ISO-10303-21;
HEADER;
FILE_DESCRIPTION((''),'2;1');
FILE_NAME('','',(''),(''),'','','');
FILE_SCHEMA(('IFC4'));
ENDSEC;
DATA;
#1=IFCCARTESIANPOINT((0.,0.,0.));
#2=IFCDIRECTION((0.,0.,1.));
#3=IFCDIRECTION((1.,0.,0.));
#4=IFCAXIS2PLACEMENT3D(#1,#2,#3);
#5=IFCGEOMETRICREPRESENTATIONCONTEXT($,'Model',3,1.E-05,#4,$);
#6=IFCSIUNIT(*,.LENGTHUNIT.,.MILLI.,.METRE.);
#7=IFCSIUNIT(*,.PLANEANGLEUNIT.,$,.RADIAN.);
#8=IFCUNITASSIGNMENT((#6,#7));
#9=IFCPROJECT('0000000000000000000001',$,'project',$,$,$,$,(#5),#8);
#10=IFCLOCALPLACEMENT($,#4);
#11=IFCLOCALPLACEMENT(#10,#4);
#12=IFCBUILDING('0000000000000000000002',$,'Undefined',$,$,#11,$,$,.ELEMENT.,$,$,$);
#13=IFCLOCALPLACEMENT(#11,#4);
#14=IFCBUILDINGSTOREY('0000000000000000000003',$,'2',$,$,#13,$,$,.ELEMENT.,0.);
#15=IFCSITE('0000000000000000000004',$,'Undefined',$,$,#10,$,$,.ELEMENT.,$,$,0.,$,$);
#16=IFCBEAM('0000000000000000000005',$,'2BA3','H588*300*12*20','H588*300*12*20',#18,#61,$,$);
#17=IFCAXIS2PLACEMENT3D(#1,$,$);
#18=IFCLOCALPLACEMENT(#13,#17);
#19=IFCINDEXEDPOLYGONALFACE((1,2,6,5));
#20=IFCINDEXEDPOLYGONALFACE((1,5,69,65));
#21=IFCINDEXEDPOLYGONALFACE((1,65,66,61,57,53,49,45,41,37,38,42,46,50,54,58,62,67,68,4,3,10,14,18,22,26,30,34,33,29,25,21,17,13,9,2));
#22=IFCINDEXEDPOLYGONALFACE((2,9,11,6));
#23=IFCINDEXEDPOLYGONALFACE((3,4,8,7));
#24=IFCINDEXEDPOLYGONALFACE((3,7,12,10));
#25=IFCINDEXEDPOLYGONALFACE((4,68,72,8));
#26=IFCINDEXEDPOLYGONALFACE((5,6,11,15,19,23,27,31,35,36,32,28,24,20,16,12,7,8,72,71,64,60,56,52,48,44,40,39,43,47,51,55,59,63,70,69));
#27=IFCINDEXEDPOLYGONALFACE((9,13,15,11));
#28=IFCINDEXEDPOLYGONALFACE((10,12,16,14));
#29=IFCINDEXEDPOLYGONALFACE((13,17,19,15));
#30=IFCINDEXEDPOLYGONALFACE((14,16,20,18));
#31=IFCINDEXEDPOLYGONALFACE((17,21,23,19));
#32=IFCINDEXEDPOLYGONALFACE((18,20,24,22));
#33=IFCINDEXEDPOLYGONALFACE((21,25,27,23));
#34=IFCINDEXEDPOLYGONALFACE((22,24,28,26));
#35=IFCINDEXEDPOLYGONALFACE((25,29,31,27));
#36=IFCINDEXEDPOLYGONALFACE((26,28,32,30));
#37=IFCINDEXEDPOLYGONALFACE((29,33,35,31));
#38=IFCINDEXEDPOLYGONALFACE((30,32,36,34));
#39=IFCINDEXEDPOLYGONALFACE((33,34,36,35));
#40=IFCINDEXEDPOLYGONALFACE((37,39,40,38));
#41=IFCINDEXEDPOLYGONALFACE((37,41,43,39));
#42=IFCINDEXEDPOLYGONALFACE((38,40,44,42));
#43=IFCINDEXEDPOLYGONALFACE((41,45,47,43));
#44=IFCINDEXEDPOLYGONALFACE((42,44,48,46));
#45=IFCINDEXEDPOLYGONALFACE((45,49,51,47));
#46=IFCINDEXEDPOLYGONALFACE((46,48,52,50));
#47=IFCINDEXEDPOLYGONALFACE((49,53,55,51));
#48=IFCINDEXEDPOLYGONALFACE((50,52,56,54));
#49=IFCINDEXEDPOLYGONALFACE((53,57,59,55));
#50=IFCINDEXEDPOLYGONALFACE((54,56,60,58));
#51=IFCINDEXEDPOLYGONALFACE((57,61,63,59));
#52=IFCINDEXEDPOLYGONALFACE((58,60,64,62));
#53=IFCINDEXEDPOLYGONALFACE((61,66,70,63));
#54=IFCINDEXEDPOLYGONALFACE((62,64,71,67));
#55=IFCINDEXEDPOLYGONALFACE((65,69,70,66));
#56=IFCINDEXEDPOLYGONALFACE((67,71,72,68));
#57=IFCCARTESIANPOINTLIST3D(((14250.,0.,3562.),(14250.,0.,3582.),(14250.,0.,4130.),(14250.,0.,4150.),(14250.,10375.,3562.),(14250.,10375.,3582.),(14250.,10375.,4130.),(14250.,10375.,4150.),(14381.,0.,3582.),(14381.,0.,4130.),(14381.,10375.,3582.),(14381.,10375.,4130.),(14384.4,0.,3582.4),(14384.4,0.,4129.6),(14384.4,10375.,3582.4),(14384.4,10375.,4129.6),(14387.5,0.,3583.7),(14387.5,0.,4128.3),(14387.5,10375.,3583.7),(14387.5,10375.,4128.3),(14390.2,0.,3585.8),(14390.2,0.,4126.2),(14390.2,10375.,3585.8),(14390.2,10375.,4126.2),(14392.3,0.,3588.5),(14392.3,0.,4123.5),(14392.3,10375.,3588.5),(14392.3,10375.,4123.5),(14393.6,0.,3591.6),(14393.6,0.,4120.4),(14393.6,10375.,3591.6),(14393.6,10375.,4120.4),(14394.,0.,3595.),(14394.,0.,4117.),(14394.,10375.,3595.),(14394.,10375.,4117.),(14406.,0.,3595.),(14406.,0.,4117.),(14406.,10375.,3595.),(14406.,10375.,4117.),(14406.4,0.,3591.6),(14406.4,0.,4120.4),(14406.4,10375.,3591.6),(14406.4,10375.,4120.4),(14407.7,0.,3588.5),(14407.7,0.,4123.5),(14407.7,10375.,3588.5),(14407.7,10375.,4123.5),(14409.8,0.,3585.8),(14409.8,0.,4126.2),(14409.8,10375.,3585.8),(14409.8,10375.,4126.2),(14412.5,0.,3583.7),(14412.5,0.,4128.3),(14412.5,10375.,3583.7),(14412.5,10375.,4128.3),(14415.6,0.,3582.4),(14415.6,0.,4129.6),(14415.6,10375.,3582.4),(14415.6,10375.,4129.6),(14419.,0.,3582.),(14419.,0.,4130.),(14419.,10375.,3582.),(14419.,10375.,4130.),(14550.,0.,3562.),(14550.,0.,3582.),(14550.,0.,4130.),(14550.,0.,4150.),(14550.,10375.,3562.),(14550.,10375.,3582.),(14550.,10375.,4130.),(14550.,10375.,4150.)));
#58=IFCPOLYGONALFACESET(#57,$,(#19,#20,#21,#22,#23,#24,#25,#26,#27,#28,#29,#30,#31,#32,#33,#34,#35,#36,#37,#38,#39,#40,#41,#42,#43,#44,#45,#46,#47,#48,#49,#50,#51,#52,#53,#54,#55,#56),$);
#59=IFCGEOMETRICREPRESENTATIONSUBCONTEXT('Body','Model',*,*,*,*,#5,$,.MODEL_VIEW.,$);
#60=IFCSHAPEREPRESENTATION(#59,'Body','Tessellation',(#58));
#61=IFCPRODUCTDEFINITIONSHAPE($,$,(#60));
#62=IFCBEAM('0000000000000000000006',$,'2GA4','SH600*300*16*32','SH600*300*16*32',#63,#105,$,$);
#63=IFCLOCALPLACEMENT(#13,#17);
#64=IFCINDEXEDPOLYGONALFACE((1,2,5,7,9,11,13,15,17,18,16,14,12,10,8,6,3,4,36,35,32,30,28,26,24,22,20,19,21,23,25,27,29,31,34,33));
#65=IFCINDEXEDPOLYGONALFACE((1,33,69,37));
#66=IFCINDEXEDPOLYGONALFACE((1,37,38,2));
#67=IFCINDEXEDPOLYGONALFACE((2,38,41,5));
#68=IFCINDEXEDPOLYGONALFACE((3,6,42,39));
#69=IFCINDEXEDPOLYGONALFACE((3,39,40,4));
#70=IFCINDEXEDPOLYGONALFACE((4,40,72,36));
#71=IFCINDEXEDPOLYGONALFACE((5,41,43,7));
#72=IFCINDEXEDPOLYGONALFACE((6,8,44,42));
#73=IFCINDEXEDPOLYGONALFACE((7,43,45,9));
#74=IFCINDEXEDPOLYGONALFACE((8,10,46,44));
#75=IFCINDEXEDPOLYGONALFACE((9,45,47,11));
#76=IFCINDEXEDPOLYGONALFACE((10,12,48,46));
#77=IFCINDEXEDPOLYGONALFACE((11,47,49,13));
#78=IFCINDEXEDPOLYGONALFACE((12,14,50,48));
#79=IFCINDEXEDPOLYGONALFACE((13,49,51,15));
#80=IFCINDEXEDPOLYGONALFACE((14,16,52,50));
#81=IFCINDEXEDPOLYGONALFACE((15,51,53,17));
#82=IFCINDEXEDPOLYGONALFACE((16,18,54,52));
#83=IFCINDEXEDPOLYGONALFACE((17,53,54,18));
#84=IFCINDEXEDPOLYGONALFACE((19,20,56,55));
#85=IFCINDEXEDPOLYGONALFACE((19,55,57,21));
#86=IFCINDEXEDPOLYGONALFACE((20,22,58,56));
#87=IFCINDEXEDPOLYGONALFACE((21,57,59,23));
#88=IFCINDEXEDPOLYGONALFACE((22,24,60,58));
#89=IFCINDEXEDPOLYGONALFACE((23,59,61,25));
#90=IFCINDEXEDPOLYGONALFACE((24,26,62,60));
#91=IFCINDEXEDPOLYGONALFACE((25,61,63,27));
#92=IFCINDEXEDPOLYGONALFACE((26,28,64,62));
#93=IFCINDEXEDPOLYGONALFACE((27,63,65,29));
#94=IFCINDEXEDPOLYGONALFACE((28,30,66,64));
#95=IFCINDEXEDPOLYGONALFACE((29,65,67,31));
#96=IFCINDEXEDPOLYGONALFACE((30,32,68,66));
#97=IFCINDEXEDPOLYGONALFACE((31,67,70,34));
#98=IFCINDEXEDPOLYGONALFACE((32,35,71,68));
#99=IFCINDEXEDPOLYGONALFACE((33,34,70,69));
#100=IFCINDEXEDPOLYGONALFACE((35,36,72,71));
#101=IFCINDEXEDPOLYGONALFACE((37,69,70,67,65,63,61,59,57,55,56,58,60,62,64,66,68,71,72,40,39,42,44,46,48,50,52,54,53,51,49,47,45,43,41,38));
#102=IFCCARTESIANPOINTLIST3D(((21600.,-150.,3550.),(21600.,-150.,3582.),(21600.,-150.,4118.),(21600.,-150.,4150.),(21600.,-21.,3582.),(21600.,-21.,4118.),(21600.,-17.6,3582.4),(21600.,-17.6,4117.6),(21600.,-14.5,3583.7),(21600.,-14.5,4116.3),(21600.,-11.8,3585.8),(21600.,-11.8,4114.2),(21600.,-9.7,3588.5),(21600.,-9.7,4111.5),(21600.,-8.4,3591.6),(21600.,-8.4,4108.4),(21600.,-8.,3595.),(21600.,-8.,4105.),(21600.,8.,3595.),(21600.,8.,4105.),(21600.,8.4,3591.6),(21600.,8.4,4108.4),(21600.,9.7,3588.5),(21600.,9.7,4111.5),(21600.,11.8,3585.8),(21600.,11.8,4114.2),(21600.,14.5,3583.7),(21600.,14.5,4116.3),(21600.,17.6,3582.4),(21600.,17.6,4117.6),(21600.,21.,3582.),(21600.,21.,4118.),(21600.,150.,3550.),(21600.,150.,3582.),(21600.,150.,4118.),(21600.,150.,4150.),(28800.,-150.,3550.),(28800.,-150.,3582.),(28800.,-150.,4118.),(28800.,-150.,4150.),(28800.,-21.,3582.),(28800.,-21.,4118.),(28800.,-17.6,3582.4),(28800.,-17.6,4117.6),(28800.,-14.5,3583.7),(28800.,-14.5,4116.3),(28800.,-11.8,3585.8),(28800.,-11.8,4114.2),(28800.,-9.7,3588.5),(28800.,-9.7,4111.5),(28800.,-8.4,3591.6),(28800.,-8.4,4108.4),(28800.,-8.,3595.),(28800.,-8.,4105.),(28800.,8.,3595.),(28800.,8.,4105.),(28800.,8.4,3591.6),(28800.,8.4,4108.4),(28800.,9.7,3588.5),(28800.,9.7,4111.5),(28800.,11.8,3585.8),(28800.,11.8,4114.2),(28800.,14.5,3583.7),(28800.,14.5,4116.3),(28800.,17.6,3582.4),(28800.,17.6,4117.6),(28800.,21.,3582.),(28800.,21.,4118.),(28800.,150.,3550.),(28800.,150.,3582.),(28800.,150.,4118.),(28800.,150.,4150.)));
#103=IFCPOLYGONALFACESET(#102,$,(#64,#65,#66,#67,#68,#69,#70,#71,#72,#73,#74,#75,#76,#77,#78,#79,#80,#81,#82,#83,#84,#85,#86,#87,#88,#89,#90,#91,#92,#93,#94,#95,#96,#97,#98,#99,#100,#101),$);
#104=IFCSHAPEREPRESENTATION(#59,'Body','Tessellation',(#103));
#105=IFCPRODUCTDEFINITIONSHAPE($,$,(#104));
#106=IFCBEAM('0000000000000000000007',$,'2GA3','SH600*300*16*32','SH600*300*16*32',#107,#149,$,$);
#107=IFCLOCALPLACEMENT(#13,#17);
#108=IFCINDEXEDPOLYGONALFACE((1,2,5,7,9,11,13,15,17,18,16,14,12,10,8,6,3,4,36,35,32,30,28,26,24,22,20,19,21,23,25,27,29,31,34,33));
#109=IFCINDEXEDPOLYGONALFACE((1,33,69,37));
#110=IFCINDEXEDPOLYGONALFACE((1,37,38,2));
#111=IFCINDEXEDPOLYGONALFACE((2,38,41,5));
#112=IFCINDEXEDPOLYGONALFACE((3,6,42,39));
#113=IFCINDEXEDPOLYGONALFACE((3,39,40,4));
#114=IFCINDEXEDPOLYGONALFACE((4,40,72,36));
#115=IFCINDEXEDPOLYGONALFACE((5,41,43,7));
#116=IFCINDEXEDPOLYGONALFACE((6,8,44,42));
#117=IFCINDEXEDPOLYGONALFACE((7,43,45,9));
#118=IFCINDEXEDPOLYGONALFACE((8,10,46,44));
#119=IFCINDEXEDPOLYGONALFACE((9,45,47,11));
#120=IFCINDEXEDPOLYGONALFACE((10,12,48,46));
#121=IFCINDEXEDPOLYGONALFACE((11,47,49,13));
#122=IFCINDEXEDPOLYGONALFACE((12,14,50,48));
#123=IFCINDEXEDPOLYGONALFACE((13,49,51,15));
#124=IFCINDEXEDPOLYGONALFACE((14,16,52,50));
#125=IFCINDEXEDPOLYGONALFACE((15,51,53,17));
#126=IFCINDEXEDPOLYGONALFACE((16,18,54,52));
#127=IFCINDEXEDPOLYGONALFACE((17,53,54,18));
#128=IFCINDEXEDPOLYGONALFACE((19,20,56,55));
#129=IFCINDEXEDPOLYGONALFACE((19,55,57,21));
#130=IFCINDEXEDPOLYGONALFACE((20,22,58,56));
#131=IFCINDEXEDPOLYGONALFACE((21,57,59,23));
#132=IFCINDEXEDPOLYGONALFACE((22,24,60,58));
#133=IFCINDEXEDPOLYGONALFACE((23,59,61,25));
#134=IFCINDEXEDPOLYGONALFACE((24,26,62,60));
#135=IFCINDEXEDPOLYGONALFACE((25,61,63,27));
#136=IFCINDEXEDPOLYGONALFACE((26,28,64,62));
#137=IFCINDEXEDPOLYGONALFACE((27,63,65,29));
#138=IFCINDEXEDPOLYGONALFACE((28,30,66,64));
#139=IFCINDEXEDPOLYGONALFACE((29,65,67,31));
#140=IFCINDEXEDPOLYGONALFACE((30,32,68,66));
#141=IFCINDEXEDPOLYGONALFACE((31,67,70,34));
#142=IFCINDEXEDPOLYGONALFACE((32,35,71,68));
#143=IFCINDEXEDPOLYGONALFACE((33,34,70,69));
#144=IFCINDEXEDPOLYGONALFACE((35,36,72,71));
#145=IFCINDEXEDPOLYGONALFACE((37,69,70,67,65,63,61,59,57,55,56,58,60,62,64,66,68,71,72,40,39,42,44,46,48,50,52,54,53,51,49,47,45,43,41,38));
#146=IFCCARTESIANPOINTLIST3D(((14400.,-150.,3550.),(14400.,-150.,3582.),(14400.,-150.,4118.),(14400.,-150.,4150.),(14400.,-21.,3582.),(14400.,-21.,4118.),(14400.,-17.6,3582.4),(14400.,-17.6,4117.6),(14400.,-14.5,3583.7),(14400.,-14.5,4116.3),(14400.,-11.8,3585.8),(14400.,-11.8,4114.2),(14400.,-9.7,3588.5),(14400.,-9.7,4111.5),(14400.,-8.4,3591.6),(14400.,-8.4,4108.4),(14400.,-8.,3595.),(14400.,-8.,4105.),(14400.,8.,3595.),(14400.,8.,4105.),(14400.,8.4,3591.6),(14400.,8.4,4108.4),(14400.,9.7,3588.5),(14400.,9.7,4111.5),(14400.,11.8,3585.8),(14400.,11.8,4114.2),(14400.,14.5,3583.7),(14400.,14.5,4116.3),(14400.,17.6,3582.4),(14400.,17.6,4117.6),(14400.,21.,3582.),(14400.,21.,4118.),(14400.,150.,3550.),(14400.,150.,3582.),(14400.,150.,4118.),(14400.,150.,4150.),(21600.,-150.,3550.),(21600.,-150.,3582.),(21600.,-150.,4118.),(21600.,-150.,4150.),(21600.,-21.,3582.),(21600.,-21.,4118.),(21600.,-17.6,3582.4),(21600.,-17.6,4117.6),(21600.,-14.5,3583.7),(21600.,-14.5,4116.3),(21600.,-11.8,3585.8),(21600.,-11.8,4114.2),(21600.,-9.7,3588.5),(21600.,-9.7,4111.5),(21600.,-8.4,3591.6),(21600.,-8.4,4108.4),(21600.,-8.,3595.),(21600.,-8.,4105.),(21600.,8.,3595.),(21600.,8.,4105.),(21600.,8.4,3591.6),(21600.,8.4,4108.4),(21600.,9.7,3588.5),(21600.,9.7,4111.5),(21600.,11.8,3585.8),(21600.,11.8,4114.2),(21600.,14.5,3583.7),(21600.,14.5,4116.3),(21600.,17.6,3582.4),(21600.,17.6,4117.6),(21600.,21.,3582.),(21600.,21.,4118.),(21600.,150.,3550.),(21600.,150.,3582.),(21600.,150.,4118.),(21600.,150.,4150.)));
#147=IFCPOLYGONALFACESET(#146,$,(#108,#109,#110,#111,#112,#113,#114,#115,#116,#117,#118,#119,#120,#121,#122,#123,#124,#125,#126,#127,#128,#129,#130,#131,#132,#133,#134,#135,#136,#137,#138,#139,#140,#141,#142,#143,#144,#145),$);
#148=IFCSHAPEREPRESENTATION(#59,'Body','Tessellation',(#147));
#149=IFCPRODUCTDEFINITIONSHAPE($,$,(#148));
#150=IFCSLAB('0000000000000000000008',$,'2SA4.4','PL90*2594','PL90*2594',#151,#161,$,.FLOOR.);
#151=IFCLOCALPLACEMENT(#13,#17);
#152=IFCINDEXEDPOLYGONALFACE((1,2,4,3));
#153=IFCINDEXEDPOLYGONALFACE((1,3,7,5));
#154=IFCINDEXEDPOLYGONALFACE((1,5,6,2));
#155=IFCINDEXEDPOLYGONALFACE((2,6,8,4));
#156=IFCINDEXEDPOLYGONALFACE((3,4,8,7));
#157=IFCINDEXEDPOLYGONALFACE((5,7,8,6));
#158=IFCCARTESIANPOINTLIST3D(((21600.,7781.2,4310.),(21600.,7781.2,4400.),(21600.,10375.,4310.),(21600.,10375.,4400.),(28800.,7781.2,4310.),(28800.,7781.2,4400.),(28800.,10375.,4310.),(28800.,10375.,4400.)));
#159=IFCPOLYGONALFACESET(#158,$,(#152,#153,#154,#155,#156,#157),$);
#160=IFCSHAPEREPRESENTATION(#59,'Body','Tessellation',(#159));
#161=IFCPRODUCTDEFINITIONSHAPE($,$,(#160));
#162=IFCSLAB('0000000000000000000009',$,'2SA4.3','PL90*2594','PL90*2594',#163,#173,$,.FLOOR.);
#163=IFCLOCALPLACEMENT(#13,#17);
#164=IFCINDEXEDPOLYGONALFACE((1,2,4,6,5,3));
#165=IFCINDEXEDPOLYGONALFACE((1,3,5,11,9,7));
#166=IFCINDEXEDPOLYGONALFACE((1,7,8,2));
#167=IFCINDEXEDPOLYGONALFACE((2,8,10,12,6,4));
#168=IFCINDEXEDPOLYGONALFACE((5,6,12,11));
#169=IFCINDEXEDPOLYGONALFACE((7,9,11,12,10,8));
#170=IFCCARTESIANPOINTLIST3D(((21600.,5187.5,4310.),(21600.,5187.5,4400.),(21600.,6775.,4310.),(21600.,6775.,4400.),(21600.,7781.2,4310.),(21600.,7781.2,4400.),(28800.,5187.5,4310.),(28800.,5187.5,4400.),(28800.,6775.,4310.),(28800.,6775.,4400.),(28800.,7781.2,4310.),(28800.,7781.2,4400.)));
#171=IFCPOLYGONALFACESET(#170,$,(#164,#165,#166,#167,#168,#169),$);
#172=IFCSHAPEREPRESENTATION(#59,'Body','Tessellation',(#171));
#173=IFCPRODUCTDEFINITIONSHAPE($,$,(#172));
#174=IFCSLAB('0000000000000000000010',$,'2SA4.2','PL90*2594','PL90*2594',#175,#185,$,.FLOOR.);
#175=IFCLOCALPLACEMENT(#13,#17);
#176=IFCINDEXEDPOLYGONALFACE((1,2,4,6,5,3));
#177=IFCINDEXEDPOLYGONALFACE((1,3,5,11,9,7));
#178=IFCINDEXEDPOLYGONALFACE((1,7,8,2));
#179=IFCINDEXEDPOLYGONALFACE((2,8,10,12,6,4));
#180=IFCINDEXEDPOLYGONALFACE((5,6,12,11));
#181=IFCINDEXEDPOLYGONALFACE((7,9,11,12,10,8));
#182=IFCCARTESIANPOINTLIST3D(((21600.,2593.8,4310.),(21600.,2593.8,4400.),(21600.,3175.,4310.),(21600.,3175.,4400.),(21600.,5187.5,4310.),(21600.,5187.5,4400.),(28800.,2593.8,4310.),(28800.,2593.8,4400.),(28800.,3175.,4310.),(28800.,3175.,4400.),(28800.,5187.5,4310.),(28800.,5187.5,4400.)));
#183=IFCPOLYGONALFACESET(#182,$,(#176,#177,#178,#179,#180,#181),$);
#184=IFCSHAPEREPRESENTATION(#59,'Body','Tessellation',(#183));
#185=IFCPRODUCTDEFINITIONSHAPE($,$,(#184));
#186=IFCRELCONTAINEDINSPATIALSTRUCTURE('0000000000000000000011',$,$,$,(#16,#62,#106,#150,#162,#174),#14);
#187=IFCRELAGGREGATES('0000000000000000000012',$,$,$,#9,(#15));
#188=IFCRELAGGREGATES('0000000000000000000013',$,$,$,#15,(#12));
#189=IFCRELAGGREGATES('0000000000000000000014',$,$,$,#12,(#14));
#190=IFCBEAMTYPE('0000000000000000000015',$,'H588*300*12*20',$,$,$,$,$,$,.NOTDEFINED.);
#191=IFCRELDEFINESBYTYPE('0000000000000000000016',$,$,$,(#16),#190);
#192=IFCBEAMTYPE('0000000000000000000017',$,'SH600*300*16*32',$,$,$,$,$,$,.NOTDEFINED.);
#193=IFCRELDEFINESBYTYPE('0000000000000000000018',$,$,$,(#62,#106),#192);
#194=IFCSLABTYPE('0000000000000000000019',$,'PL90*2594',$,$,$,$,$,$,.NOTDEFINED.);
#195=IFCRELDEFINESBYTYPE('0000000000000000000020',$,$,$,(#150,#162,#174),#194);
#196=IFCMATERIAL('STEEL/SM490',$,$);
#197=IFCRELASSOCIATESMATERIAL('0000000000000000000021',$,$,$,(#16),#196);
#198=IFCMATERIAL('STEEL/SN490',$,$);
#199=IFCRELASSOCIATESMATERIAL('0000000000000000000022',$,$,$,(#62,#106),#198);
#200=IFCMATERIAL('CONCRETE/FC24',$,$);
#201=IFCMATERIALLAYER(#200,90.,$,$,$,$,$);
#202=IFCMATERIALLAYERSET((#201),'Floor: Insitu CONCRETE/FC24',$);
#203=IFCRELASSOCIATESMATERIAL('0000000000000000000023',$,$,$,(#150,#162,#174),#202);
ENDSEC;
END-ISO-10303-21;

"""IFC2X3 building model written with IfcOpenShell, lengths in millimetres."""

from ifc_helpers import new_model, si_unit, frame, origin_with_axes, origin_2d_with_axis, place, context, subcontext, project, spatial, polyline, i_section, outline, extrude, material, layer, layer_set, layer_usage, type_object, element, save


model = new_model("IFC2X3")

# Units and contexts
model_context = context("Model", 3, precision=1e-05, world=origin_with_axes())
body_context = subcontext(model_context, "Body", "Model", "MODEL_VIEW")
ifc_project = project(units=[si_unit("LENGTHUNIT", "METRE", prefix="MILLI"), si_unit("PLANEANGLEUNIT", "RADIAN")], contexts=[model_context])

# Site, building, storey
site_placement = place(None, origin_with_axes())
site = spatial("IfcSite", under=ifc_project, at=site_placement, Name="Undefined", CompositionType="ELEMENT", RefElevation=0.0)
building_placement = place(site_placement, origin_with_axes())
building = spatial("IfcBuilding", under=site, at=building_placement, Name="Undefined", CompositionType="ELEMENT")
storey_placement = place(building_placement, origin_with_axes())
storey = spatial("IfcBuildingStorey", under=building, at=storey_placement, Name="2", CompositionType="ELEMENT", Elevation=0.0)

# Shared definitions
ifc_material_1 = material(Name="STEEL/SN490")
ifc_material_2 = material(Name="STEEL/SM490")

# Beams
beam_type_1 = type_object("IfcBeamType", Name="H588*300*12*20", PredefinedType="NOTDEFINED")
for number, where, z_axis, x_axis, name in (
    (1, (14400.0, 0.0, 3856.0), (0.0, 0.0, 1.0), (0.0, 1.0, 0.0), "2BA3"),
):
    element("IfcBeam", number, at=place(storey_placement, frame(where, z_axis=z_axis, x_axis=x_axis)), inside=storey, type_object=beam_type_1, material=ifc_material_2, Name=name, Description="H588*300*12*20", ObjectType="H588*300*12*20", context=body_context, shape_type="SweptSolid", body=[
        extrude(i_section(OverallWidth=300.0, OverallDepth=588.0, WebThickness=12.0, FlangeThickness=20.0, FilletRadius=13.0, at=origin_2d_with_axis()), frame((10375.0, 0.0, 0.0), z_axis=(-1.0, 0.0, 0.0), x_axis=(0.0, -1.0, 0.0)), (0.0, 0.0, 1.0), 10375.0),
    ])
beam_type_2 = type_object("IfcBeamType", Name="SH600*300*16*32", PredefinedType="NOTDEFINED")
for number, where, z_axis, x_axis, name in (
    (2, (21600.0, 0.0, 3850.0), (0.0, 0.0, 1.0), (1.0, 0.0, 0.0), "2GA4"),
    (3, (14400.0, 0.0, 3850.0), (0.0, 0.0, 1.0), (1.0, 0.0, 0.0), "2GA3"),
):
    element("IfcBeam", number, at=place(storey_placement, frame(where, z_axis=z_axis, x_axis=x_axis)), inside=storey, type_object=beam_type_2, material=ifc_material_1, Name=name, Description="SH600*300*16*32", ObjectType="SH600*300*16*32", context=body_context, shape_type="SweptSolid", body=[
        extrude(i_section(OverallWidth=300.0, OverallDepth=600.0, WebThickness=16.0, FlangeThickness=32.0, FilletRadius=13.0, at=origin_2d_with_axis()), frame((7200.0, 0.0, 0.0), z_axis=(-1.0, 0.0, 0.0), x_axis=(0.0, -1.0, 0.0)), (0.0, 0.0, 1.0), 7200.0),
    ])

# Slabs
ifc_material_3 = material(Name="CONCRETE/FC24")
ifc_layer = layer(ifc_material_3, 90.0)
ifc_layer_set = layer_set([ifc_layer], Name="Floor: Insitu CONCRETE/FC24")
ifc_layer_usage_1 = layer_usage(ifc_layer_set, "AXIS3", "POSITIVE", -45.0)
slab_type = type_object("IfcSlabType", Name="PL90*2594", PredefinedType="NOTDEFINED")
slab_1_placement = place(storey_placement, frame((21600.0, 7781.2, 4355.0), z_axis=(0.0, 0.0, 1.0), x_axis=(1.0, 0.0, 0.0)))
element("IfcSlab", 4, at=slab_1_placement, inside=storey, type_object=slab_type, material=ifc_layer_usage_1, Name="2SA4.4", Description="PL90*2594", ObjectType="PL90*2594", PredefinedType="FLOOR", context=body_context, shape_type="SweptSolid", body=[
    extrude(outline(polyline([(0.0, 0.0), (7200.0, 0.0), (7200.0, 2593.8), (0.0, 2593.8), (0.0, 0.0)])), frame((0.0, 0.0, -45.0), z_axis=(0.0, 0.0, 1.0), x_axis=(1.0, 0.0, 0.0)), (0.0, 0.0, 1.0), 90.0),
])
ifc_layer_usage_2 = layer_usage(ifc_layer_set, "AXIS3", "POSITIVE", -45.0)
slab_2_placement = place(storey_placement, frame((21600.0, 5187.5, 4355.0), z_axis=(0.0, 0.0, 1.0), x_axis=(1.0, 0.0, 0.0)))
element("IfcSlab", 5, at=slab_2_placement, inside=storey, type_object=slab_type, material=ifc_layer_usage_2, Name="2SA4.3", Description="PL90*2594", ObjectType="PL90*2594", PredefinedType="FLOOR", context=body_context, shape_type="SweptSolid", body=[
    extrude(outline(polyline([(0.0, 0.0), (7200.0, 0.0), (7200.0, 1587.5), (7200.0, 2593.8), (0.0, 2593.8), (0.0, 1587.5), (0.0, 0.0)])), frame((0.0, 0.0, -45.0), z_axis=(0.0, 0.0, 1.0), x_axis=(1.0, 0.0, 0.0)), (0.0, 0.0, 1.0), 90.0),
])
ifc_layer_usage_3 = layer_usage(ifc_layer_set, "AXIS3", "POSITIVE", -45.0)
slab_3_placement = place(storey_placement, frame((21600.0, 2593.8, 4355.0), z_axis=(0.0, 0.0, 1.0), x_axis=(1.0, 0.0, 0.0)))
element("IfcSlab", 6, at=slab_3_placement, inside=storey, type_object=slab_type, material=ifc_layer_usage_3, Name="2SA4.2", Description="PL90*2594", ObjectType="PL90*2594", PredefinedType="FLOOR", context=body_context, shape_type="SweptSolid", body=[
    extrude(outline(polyline([(0.0, 0.0), (7200.0, 0.0), (7200.0, 581.2), (7200.0, 2593.8), (0.0, 2593.8), (0.0, 581.2), (0.0, 0.0)])), frame((0.0, 0.0, -45.0), z_axis=(0.0, 0.0, 1.0), x_axis=(1.0, 0.0, 0.0)), (0.0, 0.0, 1.0), 90.0),
])

save(model, "model.ifc")
